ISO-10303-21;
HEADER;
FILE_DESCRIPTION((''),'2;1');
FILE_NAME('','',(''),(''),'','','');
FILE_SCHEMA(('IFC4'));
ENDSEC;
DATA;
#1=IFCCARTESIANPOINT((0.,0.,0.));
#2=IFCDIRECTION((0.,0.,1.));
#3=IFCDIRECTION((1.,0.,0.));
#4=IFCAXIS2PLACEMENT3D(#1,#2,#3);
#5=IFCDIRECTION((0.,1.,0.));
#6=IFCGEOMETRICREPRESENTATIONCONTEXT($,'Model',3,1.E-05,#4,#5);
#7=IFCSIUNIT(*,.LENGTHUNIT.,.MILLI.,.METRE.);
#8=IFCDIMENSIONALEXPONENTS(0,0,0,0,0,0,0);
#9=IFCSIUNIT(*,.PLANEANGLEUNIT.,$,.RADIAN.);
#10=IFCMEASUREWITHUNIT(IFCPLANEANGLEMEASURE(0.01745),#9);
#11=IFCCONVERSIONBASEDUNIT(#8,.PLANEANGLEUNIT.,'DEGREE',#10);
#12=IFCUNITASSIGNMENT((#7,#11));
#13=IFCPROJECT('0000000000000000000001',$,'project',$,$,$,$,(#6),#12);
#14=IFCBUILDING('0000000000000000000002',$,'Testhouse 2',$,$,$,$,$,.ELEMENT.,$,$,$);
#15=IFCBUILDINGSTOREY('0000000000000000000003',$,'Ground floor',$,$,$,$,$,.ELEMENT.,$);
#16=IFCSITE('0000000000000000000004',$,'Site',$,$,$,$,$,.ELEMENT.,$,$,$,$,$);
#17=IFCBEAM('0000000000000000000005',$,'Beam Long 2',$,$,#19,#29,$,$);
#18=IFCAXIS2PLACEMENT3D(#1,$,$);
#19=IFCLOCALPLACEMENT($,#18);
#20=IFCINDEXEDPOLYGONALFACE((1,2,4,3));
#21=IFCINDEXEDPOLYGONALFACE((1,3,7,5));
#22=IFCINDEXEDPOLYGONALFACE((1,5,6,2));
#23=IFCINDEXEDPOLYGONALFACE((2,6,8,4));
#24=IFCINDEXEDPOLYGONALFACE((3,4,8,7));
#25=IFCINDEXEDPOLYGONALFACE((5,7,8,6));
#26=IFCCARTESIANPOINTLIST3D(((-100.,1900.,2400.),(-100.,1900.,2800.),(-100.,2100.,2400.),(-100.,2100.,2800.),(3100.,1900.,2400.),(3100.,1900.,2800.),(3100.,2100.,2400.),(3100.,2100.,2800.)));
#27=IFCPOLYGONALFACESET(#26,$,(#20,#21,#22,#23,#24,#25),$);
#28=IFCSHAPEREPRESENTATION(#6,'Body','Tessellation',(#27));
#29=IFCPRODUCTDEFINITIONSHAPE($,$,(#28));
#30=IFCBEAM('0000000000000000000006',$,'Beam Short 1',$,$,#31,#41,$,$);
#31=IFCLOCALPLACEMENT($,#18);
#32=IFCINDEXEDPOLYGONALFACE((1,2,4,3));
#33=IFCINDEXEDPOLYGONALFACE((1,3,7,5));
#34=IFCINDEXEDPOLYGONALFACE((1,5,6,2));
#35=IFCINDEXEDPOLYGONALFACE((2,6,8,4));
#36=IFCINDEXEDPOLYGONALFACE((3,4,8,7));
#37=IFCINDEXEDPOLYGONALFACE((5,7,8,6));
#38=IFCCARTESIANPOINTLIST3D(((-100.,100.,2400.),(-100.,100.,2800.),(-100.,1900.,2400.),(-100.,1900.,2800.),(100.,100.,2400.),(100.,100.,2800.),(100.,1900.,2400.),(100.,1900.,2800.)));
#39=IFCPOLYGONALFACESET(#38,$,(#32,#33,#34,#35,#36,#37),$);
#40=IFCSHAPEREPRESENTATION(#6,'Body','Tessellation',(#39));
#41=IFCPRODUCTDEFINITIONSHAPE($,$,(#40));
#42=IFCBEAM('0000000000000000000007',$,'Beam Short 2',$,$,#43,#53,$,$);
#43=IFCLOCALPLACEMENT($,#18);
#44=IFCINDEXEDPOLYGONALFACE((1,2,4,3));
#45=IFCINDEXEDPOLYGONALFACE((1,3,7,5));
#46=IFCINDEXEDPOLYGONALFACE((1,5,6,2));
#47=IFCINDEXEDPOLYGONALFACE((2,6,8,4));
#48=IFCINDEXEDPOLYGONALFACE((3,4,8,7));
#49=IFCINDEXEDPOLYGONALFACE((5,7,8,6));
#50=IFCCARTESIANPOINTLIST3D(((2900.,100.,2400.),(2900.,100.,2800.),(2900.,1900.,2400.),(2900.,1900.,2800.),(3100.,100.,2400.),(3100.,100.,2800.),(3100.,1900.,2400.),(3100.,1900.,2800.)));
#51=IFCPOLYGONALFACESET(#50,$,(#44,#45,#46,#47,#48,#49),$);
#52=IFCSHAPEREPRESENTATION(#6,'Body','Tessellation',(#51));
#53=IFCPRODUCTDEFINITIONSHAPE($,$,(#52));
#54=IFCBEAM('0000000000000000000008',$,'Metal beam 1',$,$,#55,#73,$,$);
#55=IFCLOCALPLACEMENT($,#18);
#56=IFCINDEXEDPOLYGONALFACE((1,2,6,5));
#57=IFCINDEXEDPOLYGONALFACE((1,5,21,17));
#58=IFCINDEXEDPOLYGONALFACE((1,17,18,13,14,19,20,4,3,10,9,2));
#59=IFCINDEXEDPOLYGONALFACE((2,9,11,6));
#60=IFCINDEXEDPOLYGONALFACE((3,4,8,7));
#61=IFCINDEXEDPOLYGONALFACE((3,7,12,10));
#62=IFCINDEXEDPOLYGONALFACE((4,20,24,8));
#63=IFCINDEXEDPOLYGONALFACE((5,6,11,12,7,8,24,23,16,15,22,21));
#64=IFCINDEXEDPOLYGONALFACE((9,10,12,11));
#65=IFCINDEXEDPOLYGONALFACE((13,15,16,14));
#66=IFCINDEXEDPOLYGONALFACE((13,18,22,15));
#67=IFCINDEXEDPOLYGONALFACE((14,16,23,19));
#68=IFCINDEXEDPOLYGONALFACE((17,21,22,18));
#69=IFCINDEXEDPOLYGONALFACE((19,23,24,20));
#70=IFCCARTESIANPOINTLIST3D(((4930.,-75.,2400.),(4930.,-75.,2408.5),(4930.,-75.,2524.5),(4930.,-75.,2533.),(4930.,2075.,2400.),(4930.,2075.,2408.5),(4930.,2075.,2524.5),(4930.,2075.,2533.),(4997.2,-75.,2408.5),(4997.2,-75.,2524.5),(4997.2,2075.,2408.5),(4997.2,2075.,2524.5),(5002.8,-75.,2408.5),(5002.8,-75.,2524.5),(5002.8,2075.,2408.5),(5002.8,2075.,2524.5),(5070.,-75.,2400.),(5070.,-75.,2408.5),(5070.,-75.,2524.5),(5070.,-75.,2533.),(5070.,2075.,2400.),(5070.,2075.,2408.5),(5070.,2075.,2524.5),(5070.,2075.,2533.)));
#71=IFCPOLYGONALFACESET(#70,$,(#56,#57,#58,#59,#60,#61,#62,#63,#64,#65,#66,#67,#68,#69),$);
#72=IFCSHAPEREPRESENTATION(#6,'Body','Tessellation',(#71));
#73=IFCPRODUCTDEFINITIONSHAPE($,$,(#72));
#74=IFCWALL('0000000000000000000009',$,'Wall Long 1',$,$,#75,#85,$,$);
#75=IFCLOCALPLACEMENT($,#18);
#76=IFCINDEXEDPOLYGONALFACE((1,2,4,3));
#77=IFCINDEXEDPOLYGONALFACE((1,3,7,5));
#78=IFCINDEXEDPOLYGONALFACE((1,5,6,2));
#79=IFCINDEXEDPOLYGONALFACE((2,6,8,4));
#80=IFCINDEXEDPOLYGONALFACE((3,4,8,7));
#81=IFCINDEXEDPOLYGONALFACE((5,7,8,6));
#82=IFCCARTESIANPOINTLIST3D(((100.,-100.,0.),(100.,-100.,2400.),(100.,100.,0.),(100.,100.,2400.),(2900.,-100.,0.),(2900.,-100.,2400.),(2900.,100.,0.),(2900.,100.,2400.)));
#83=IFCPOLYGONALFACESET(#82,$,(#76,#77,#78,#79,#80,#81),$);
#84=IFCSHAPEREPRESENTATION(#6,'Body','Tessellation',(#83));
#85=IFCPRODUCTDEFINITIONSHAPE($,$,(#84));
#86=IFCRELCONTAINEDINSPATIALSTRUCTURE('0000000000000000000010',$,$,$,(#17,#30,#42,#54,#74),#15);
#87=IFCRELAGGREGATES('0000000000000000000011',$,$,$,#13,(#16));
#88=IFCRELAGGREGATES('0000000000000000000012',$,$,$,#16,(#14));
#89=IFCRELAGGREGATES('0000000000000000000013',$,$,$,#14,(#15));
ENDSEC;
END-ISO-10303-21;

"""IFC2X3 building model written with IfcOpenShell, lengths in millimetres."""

from ifc_helpers import new_model, entity, si_unit, converted_unit, direction, frame, origin_with_axes, place, context, project, spatial, polyline, outline, extrude, element, save


model = new_model("IFC2X3")

# Units and contexts
model_context = context("Model", 3, precision=1e-05, world=origin_with_axes(), true_north=direction((0.0, 1.0, 0.0)))
ifc_project = project(units=[si_unit("LENGTHUNIT", "METRE", prefix="MILLI"), converted_unit("PLANEANGLEUNIT", "DEGREE", entity("IfcPlaneAngleMeasure", 0.01745), si_unit("PLANEANGLEUNIT", "RADIAN"), dimensions=[0, 0, 0, 0, 0, 0, 0])], contexts=[model_context])

# Site, building, storey
site = spatial("IfcSite", under=ifc_project, Name="Site", CompositionType="ELEMENT")
building = spatial("IfcBuilding", under=site, Name="Testhouse 2", CompositionType="ELEMENT")
storey = spatial("IfcBuildingStorey", under=building, Name="Ground floor", CompositionType="ELEMENT")

# Beams
beam_1_placement = place(None, origin_with_axes())
element("IfcBeam", 1, at=beam_1_placement, inside=storey, Name="Beam Long 2", context=model_context, shape_type="SweptSolid", body=[
    extrude(outline(polyline([(-200.0, -100.0), (200.0, -100.0), (200.0, 100.0), (-200.0, 100.0), (-200.0, -100.0)])), frame((-100.0, 2000.0, 2600.0), z_axis=(1.0, 0.0, 0.0), x_axis=(0.0, 0.0, -1.0)), (0.0, 0.0, 1.0), 3200.0),
])
beam_2_placement = place(None, origin_with_axes())
element("IfcBeam", 2, at=beam_2_placement, inside=storey, Name="Beam Short 1", context=model_context, shape_type="SweptSolid", body=[
    extrude(outline(polyline([(-200.0, -100.0), (200.0, -100.0), (200.0, 100.0), (-200.0, 100.0), (-200.0, -100.0)])), frame((0.0, 100.0, 2600.0), z_axis=(0.0, 1.0, 0.0), x_axis=(0.0, 0.0, -1.0)), (0.0, 0.0, 1.0), 1800.0),
])
beam_3_placement = place(None, origin_with_axes())
element("IfcBeam", 3, at=beam_3_placement, inside=storey, Name="Beam Short 2", context=model_context, shape_type="SweptSolid", body=[
    extrude(outline(polyline([(-200.0, -100.0), (200.0, -100.0), (200.0, 100.0), (-200.0, 100.0), (-200.0, -100.0)])), frame((3000.0, 100.0, 2600.0), z_axis=(0.0, 1.0, 0.0), x_axis=(0.0, 0.0, -1.0)), (0.0, 0.0, 1.0), 1800.0),
])
beam_4_placement = place(None, origin_with_axes())
element("IfcBeam", 4, at=beam_4_placement, inside=storey, Name="Metal beam 1", context=model_context, shape_type="SweptSolid", body=[
    extrude(outline(polyline([(-70.0, -66.5), (70.0, -66.5), (70.0, -58.0), (2.8, -58.0), (2.8, 58.0), (70.0, 58.0), (70.0, 66.5), (-70.0, 66.5), (-70.0, 58.0), (-2.8, 58.0), (-2.8, -58.0), (-70.0, -58.0), (-70.0, -66.5)])), frame((5000.0, 2075.0, 2466.5), z_axis=(0.0, -1.0, 0.0), x_axis=(1.0, 0.0, 0.0)), (0.0, 0.0, 1.0), 2150.0),
])

# Wall
wall_1_placement = place(None, origin_with_axes())
element("IfcWall", 5, at=wall_1_placement, inside=storey, Name="Wall Long 1", context=model_context, shape_type="SweptSolid", body=[
    extrude(outline(polyline([(100.0, -100.0), (2900.0, -100.0), (2900.0, 100.0), (100.0, 100.0), (100.0, -100.0)])), origin_with_axes(), (0.0, 0.0, 1.0), 2400.0),
])

save(model, "model.ifc")
